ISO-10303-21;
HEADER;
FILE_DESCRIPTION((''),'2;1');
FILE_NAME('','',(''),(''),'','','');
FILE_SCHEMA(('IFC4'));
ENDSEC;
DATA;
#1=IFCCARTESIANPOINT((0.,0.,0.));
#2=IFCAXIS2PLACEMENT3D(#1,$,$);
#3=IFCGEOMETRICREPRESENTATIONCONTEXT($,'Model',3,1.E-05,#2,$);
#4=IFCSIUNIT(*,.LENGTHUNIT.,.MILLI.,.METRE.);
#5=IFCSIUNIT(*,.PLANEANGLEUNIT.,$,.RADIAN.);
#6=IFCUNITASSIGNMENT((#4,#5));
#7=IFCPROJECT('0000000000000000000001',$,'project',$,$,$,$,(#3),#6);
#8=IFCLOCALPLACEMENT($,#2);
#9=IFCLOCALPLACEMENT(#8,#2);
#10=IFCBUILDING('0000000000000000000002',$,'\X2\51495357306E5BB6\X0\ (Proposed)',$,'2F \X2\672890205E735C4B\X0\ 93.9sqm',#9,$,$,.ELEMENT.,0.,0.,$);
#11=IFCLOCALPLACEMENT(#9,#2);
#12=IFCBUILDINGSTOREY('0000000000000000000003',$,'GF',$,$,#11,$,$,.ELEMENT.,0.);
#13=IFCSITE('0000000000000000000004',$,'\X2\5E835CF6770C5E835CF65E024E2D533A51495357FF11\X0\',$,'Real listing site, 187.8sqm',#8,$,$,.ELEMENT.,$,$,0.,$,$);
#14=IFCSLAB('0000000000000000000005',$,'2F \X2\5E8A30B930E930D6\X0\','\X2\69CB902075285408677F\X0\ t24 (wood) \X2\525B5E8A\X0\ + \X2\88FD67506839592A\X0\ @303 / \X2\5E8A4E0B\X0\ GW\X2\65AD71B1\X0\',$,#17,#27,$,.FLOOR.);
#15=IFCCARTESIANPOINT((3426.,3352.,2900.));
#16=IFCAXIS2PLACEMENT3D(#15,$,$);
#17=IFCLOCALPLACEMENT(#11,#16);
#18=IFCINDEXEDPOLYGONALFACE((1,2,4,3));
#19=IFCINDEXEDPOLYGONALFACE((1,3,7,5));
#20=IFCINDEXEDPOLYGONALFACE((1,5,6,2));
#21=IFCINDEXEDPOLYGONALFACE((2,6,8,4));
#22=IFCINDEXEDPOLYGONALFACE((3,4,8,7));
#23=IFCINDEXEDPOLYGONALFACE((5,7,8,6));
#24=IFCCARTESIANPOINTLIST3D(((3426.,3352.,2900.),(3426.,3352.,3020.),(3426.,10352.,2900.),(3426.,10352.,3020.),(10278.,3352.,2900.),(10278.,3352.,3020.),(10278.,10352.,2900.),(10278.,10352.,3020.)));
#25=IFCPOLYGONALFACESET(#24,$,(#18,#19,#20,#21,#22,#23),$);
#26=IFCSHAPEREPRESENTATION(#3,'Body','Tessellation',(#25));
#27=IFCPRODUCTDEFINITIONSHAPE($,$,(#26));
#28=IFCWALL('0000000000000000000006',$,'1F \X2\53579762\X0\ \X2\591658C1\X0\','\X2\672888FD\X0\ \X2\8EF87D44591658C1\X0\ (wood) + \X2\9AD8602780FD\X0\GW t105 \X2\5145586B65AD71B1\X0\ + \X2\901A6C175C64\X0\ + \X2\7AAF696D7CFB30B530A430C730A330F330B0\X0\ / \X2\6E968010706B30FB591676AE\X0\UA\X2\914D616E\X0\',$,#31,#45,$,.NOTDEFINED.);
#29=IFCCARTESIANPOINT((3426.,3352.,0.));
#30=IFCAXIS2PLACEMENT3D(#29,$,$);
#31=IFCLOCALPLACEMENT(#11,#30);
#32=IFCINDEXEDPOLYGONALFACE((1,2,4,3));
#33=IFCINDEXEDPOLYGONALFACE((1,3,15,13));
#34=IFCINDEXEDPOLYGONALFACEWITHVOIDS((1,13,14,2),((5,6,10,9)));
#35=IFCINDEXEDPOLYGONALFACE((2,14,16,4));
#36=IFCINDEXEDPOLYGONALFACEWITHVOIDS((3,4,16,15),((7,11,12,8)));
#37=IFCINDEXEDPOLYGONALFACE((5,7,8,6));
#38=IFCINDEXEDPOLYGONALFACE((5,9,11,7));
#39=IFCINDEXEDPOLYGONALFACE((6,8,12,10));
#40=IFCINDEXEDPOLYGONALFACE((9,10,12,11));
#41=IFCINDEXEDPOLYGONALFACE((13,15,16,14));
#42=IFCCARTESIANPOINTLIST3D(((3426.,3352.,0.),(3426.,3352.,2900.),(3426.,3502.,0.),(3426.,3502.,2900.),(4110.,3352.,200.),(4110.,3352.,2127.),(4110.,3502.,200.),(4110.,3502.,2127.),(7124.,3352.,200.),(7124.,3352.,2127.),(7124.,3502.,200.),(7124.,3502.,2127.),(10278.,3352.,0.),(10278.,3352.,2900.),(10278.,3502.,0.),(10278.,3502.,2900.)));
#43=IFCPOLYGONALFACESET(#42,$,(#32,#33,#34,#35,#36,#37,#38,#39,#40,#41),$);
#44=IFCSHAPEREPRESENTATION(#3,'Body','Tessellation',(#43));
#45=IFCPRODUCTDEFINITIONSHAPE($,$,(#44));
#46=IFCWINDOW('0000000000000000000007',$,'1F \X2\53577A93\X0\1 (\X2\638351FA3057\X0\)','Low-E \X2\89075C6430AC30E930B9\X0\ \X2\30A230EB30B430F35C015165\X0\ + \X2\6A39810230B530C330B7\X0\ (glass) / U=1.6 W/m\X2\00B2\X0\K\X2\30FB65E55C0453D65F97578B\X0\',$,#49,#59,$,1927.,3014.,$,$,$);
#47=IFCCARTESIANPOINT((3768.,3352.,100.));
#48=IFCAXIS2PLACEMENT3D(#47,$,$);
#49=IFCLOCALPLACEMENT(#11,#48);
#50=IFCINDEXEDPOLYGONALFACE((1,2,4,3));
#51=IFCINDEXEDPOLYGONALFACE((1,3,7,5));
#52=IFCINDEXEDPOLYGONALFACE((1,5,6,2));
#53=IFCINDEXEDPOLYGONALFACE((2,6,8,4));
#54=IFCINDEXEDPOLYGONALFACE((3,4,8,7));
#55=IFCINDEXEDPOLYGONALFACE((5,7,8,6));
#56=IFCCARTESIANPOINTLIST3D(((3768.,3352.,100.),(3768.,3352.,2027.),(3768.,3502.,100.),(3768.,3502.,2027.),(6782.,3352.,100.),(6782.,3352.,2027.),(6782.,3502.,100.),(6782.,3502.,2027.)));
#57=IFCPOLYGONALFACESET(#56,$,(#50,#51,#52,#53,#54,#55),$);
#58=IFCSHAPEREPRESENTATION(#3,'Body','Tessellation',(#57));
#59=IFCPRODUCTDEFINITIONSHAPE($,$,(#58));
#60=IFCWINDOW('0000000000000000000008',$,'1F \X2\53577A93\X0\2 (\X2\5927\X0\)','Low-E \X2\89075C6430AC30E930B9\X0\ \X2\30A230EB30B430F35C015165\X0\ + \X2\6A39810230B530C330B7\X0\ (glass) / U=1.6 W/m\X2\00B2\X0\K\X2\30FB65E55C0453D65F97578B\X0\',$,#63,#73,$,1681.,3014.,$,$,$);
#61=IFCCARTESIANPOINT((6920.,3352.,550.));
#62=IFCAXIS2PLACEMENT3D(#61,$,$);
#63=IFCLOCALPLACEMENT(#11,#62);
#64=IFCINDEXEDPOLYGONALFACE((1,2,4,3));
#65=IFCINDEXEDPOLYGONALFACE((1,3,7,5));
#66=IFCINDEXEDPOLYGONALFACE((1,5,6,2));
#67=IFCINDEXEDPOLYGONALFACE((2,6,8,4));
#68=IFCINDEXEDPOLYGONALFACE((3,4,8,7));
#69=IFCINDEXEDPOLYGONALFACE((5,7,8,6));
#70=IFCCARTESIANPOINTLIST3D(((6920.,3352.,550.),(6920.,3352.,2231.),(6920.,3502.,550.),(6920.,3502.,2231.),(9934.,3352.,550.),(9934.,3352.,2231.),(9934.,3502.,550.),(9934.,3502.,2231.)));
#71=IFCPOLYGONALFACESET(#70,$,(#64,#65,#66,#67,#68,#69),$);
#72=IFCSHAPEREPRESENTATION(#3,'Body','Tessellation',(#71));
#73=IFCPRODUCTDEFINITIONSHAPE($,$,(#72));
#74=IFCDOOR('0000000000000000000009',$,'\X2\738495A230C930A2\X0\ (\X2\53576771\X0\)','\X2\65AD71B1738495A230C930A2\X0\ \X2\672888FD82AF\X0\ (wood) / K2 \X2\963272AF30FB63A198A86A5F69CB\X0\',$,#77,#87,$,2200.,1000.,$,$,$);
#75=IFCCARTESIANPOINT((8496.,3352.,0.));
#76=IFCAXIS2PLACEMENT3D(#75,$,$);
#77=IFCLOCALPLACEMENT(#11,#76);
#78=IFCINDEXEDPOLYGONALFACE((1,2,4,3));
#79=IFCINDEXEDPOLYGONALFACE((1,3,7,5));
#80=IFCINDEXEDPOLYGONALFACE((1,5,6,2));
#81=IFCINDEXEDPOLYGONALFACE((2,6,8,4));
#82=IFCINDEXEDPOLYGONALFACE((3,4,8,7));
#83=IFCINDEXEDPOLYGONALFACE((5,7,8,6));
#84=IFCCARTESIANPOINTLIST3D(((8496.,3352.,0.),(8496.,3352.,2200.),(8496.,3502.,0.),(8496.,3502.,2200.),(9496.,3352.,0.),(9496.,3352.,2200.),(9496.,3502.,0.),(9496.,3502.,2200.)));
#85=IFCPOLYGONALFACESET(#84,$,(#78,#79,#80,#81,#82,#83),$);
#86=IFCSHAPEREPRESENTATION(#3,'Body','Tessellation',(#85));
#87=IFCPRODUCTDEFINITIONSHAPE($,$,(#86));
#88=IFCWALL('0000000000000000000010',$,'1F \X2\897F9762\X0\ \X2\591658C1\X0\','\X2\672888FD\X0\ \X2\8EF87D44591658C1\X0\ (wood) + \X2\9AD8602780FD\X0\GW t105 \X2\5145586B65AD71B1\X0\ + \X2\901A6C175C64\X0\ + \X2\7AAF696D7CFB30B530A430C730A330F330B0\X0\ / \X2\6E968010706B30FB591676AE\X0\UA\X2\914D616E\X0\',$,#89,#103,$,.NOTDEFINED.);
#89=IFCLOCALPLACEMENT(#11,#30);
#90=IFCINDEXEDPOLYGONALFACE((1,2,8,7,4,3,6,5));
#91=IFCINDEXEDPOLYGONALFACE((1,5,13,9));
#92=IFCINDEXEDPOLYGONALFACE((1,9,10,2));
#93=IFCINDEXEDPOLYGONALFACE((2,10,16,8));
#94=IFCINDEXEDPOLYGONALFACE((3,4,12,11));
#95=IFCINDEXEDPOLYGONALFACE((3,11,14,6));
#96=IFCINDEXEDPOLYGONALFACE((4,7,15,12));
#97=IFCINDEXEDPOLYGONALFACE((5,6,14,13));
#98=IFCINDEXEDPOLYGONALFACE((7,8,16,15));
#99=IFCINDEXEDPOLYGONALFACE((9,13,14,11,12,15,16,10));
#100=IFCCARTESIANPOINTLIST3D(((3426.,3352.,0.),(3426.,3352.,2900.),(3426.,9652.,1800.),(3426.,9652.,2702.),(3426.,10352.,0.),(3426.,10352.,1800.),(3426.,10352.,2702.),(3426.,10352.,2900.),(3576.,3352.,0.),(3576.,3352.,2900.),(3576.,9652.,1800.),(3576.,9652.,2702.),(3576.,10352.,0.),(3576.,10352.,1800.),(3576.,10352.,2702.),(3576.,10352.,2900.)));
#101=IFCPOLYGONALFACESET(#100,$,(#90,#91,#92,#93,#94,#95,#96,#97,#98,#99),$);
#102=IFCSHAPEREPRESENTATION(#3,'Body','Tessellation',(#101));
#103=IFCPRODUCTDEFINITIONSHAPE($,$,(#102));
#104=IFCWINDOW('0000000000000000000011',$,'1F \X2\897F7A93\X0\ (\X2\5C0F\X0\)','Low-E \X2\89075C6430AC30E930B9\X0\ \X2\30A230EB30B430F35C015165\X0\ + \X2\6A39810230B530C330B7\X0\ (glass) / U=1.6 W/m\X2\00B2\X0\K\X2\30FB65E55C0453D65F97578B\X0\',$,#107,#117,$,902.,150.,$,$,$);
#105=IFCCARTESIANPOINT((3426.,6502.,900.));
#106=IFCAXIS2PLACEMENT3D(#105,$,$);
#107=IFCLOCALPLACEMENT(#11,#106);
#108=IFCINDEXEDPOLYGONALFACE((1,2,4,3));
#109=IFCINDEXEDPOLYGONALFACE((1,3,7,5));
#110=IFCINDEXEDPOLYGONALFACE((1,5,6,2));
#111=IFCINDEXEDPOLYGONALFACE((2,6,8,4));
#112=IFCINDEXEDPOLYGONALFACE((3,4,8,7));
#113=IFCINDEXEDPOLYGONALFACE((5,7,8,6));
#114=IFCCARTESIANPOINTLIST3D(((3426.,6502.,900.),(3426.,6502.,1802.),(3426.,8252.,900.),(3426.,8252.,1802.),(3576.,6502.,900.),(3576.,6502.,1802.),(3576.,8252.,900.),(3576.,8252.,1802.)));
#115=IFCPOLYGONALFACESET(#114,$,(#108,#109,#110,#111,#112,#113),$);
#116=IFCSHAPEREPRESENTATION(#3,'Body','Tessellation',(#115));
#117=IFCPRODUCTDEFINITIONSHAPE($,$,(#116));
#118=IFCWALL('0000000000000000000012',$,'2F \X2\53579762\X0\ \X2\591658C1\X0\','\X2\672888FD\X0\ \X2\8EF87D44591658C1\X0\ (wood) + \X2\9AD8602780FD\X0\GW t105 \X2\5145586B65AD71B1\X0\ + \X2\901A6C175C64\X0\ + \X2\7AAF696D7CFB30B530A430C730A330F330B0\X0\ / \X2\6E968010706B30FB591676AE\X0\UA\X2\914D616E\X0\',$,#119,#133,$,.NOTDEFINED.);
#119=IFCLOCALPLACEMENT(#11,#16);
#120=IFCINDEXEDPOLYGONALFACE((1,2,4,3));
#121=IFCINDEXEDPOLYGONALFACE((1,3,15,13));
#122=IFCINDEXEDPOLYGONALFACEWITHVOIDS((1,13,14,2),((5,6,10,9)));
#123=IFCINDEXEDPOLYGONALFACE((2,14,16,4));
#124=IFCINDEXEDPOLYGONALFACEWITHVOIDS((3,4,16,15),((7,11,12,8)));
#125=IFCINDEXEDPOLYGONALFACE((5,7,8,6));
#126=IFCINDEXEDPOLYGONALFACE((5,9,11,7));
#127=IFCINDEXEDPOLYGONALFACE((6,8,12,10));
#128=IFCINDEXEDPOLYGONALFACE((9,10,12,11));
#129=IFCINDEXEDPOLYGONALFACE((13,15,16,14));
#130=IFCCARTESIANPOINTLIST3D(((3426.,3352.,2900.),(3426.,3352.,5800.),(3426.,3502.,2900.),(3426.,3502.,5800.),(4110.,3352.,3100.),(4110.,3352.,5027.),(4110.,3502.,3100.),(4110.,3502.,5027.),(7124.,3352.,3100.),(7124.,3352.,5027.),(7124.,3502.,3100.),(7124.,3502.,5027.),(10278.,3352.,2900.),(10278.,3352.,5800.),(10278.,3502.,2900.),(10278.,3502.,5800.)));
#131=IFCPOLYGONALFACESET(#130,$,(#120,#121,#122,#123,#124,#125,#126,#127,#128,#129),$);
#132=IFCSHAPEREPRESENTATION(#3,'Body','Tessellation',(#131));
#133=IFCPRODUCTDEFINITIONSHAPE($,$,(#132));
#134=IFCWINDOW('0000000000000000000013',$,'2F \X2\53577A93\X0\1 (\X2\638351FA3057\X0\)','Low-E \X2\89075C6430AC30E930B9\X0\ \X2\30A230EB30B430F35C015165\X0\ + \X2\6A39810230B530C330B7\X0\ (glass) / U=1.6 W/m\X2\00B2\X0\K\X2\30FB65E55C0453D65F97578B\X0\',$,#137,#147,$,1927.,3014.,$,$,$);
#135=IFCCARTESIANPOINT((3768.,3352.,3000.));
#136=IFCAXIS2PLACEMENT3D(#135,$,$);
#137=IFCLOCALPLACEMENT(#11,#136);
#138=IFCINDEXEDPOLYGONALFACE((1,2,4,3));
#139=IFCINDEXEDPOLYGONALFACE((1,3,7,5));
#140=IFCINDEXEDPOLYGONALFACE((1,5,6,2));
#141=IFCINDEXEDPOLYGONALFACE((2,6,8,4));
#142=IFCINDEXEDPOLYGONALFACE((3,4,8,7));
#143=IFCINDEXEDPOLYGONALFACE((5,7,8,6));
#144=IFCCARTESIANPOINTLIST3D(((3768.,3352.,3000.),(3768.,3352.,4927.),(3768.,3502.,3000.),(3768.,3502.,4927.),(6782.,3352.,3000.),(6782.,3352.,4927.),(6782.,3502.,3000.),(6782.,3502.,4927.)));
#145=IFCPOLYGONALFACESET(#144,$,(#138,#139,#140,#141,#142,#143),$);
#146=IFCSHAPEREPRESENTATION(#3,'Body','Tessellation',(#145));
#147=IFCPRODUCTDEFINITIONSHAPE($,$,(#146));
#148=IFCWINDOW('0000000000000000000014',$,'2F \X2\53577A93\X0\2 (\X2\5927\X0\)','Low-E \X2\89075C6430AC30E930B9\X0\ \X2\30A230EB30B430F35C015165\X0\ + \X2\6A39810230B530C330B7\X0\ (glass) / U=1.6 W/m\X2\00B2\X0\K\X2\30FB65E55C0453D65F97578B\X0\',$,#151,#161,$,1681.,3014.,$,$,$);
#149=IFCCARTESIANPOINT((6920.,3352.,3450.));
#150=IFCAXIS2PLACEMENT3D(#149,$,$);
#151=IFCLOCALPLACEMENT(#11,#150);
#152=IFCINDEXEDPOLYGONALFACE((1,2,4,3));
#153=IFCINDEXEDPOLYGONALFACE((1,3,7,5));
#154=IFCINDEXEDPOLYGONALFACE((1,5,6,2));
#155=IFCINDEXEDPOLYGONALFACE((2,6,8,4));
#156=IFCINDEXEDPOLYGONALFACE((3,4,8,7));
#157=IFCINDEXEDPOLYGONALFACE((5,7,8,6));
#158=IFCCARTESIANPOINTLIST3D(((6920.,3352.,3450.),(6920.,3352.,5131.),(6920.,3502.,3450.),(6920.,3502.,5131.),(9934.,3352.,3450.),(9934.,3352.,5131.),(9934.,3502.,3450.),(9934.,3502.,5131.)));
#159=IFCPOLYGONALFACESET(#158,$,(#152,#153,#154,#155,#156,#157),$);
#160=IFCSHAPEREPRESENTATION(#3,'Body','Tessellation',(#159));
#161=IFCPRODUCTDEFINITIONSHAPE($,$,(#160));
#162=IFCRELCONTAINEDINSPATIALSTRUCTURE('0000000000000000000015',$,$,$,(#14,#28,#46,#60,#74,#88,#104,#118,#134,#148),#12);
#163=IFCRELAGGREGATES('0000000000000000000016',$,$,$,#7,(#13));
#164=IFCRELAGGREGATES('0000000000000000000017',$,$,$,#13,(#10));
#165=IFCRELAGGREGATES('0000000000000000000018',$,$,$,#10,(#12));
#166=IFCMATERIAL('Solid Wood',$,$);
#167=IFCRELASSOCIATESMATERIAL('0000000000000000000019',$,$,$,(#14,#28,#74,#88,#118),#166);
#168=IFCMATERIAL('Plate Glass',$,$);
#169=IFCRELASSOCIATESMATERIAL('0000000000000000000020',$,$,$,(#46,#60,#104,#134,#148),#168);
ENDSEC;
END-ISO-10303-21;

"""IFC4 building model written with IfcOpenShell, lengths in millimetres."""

from ifc_helpers import new_model, si_unit, frame, frame_2d, origin, place, context, project, spatial, rectangle, extrude, material, element, fill, save


model = new_model("IFC4")

# Units and contexts
model_context = context("Model", 3, precision=1e-05, world=origin())
ifc_project = project(units=[si_unit("LENGTHUNIT", "METRE", prefix="MILLI"), si_unit("PLANEANGLEUNIT", "RADIAN")], contexts=[model_context])

# Site, building, storey
site_placement = place(None, origin())
site = spatial("IfcSite", under=ifc_project, at=site_placement, Name="広島県広島市中区光南１", ObjectType="Real listing site, 187.8sqm", CompositionType="ELEMENT", RefElevation=0.0)
building_placement = place(site_placement, origin())
building = spatial("IfcBuilding", under=site, at=building_placement, Name="光南の家 (Proposed)", ObjectType="2F 木造平屋 93.9sqm", CompositionType="ELEMENT", ElevationOfRefHeight=0.0, ElevationOfTerrain=0.0)
storey_placement = place(building_placement, origin())
storey = spatial("IfcBuildingStorey", under=building, at=storey_placement, Name="GF", CompositionType="ELEMENT", Elevation=0.0)

# Slab
ifc_material_1 = material(Name="Solid Wood")
slab_1_placement = place(storey_placement, frame((3426.0, 3352.0, 2900.0)))
element("IfcSlab", 1, at=slab_1_placement, inside=storey, material=ifc_material_1, Name="2F 床スラブ", Description="構造用合板 t24 (wood) 剛床 + 製材根太 @303 / 床下 GW断熱", PredefinedType="FLOOR", context=model_context, shape_type="SweptSolid", body=[
    extrude(rectangle(XDim=6852.0, YDim=7000.0, at=frame_2d((3426.0, 3500.0))), frame((3426.0, 3352.0, 2900.0)), (0.0, 0.0, 1.0), 120.0),
])

# Wall, openings, windows, door
wall_1_placement = place(storey_placement, frame((3426.0, 3352.0, 0.0)))
wall_1 = element("IfcWall", 2, at=wall_1_placement, inside=storey, material=ifc_material_1, Name="1F 南面 外壁", Description="木製 軸組外壁 (wood) + 高性能GW t105 充填断熱 + 通気層 + 窯業系サイディング / 準耐火・外皮UA配慮", PredefinedType="NOTDEFINED", context=model_context, shape_type="SweptSolid", body=[
    extrude(rectangle(XDim=6852.0, YDim=150.0, at=frame_2d((3426.0, 75.0))), frame((3426.0, 3352.0, 0.0)), (0.0, 0.0, 1.0), 2900.0),
])
opening_1_placement = place(storey_placement, frame((3768.0, 3352.0, 100.0)))
opening_1 = element("IfcOpeningElement", 3, at=opening_1_placement, cuts=wall_1, PredefinedType="NOTDEFINED", context=model_context, shape_type="SweptSolid", body=[
    extrude(rectangle(XDim=3014.0, YDim=150.0, at=frame_2d((1507.0, 75.0))), frame((3768.0, 3352.0, 100.0)), (0.0, 0.0, 1.0), 1927.0),
])
opening_2_placement = place(storey_placement, frame((6920.0, 3352.0, 550.0)))
opening_2 = element("IfcOpeningElement", 4, at=opening_2_placement, cuts=wall_1, PredefinedType="NOTDEFINED", context=model_context, shape_type="SweptSolid", body=[
    extrude(rectangle(XDim=3014.0, YDim=150.0, at=frame_2d((1507.0, 75.0))), frame((6920.0, 3352.0, 550.0)), (0.0, 0.0, 1.0), 1681.0),
])
opening_3_placement = place(storey_placement, frame((8496.0, 3352.0, 0.0)))
opening_3 = element("IfcOpeningElement", 5, at=opening_3_placement, cuts=wall_1, PredefinedType="NOTDEFINED", context=model_context, shape_type="SweptSolid", body=[
    extrude(rectangle(XDim=1000.0, YDim=150.0, at=frame_2d((500.0, 75.0))), frame((8496.0, 3352.0, 0.0)), (0.0, 0.0, 1.0), 2200.0),
])
ifc_material_2 = material(Name="Plate Glass")
window_1_placement = place(storey_placement, frame((3768.0, 3352.0, 100.0)))
window_1 = element("IfcWindow", 6, at=window_1_placement, inside=storey, material=ifc_material_2, Name="1F 南窓1 (掃出し)", Description="Low-E 複層ガラス アルゴン封入 + 樹脂サッシ (glass) / U=1.6 W/m²K・日射取得型", OverallHeight=1927.0, OverallWidth=3014.0, context=model_context, shape_type="SweptSolid", body=[
    extrude(rectangle(XDim=3014.0, YDim=150.0, at=frame_2d((1507.0, 75.0))), frame((3768.0, 3352.0, 100.0)), (0.0, 0.0, 1.0), 1927.0),
])
fill(opening_1, window_1)
window_2_placement = place(storey_placement, frame((6920.0, 3352.0, 550.0)))
window_2 = element("IfcWindow", 7, at=window_2_placement, inside=storey, material=ifc_material_2, Name="1F 南窓2 (大)", Description="Low-E 複層ガラス アルゴン封入 + 樹脂サッシ (glass) / U=1.6 W/m²K・日射取得型", OverallHeight=1681.0, OverallWidth=3014.0, context=model_context, shape_type="SweptSolid", body=[
    extrude(rectangle(XDim=3014.0, YDim=150.0, at=frame_2d((1507.0, 75.0))), frame((6920.0, 3352.0, 550.0)), (0.0, 0.0, 1.0), 1681.0),
])
fill(opening_2, window_2)
door_placement = place(storey_placement, frame((8496.0, 3352.0, 0.0)))
door = element("IfcDoor", 8, at=door_placement, inside=storey, material=ifc_material_1, Name="玄関ドア (南東)", Description="断熱玄関ドア 木製芯 (wood) / K2 防犯・採風機構", OverallHeight=2200.0, OverallWidth=1000.0, context=model_context, shape_type="SweptSolid", body=[
    extrude(rectangle(XDim=1000.0, YDim=150.0, at=frame_2d((500.0, 75.0))), frame((8496.0, 3352.0, 0.0)), (0.0, 0.0, 1.0), 2200.0),
])
fill(opening_3, door)

# Wall, opening, window
wall_2_placement = place(storey_placement, frame((3426.0, 3352.0, 0.0)))
wall_2 = element("IfcWall", 9, at=wall_2_placement, inside=storey, material=ifc_material_1, Name="1F 西面 外壁", Description="木製 軸組外壁 (wood) + 高性能GW t105 充填断熱 + 通気層 + 窯業系サイディング / 準耐火・外皮UA配慮", PredefinedType="NOTDEFINED", context=model_context, shape_type="SweptSolid", body=[
    extrude(rectangle(XDim=150.0, YDim=7000.0, at=frame_2d((75.0, 3500.0))), frame((3426.0, 3352.0, 0.0)), (0.0, 0.0, 1.0), 2900.0),
])
opening_4_placement = place(storey_placement, frame((3426.0, 6502.0, 900.0)))
opening_4 = element("IfcOpeningElement", 10, at=opening_4_placement, cuts=wall_2, PredefinedType="NOTDEFINED", context=model_context, shape_type="SweptSolid", body=[
    extrude(rectangle(XDim=150.0, YDim=1750.0, at=frame_2d((75.0, 875.0))), frame((3426.0, 6502.0, 900.0)), (0.0, 0.0, 1.0), 902.0),
])
window_3_placement = place(storey_placement, frame((3426.0, 6502.0, 900.0)))
window_3 = element("IfcWindow", 11, at=window_3_placement, inside=storey, material=ifc_material_2, Name="1F 西窓 (小)", Description="Low-E 複層ガラス アルゴン封入 + 樹脂サッシ (glass) / U=1.6 W/m²K・日射取得型", OverallHeight=902.0, OverallWidth=150.0, context=model_context, shape_type="SweptSolid", body=[
    extrude(rectangle(XDim=150.0, YDim=1750.0, at=frame_2d((75.0, 875.0))), frame((3426.0, 6502.0, 900.0)), (0.0, 0.0, 1.0), 902.0),
])
fill(opening_4, window_3)

# Wall, openings, windows
wall_3_placement = place(storey_placement, frame((3426.0, 3352.0, 2900.0)))
wall_3 = element("IfcWall", 12, at=wall_3_placement, inside=storey, material=ifc_material_1, Name="2F 南面 外壁", Description="木製 軸組外壁 (wood) + 高性能GW t105 充填断熱 + 通気層 + 窯業系サイディング / 準耐火・外皮UA配慮", PredefinedType="NOTDEFINED", context=model_context, shape_type="SweptSolid", body=[
    extrude(rectangle(XDim=6852.0, YDim=150.0, at=frame_2d((3426.0, 75.0))), frame((3426.0, 3352.0, 2900.0)), (0.0, 0.0, 1.0), 2900.0),
])
opening_5_placement = place(storey_placement, frame((3768.0, 3352.0, 3000.0)))
opening_5 = element("IfcOpeningElement", 13, at=opening_5_placement, cuts=wall_3, PredefinedType="NOTDEFINED", context=model_context, shape_type="SweptSolid", body=[
    extrude(rectangle(XDim=3014.0, YDim=150.0, at=frame_2d((1507.0, 75.0))), frame((3768.0, 3352.0, 3000.0)), (0.0, 0.0, 1.0), 1927.0),
])
opening_6_placement = place(storey_placement, frame((6920.0, 3352.0, 3450.0)))
opening_6 = element("IfcOpeningElement", 14, at=opening_6_placement, cuts=wall_3, PredefinedType="NOTDEFINED", context=model_context, shape_type="SweptSolid", body=[
    extrude(rectangle(XDim=3014.0, YDim=150.0, at=frame_2d((1507.0, 75.0))), frame((6920.0, 3352.0, 3450.0)), (0.0, 0.0, 1.0), 1681.0),
])
window_4_placement = place(storey_placement, frame((3768.0, 3352.0, 3000.0)))
window_4 = element("IfcWindow", 15, at=window_4_placement, inside=storey, material=ifc_material_2, Name="2F 南窓1 (掃出し)", Description="Low-E 複層ガラス アルゴン封入 + 樹脂サッシ (glass) / U=1.6 W/m²K・日射取得型", OverallHeight=1927.0, OverallWidth=3014.0, context=model_context, shape_type="SweptSolid", body=[
    extrude(rectangle(XDim=3014.0, YDim=150.0, at=frame_2d((1507.0, 75.0))), frame((3768.0, 3352.0, 3000.0)), (0.0, 0.0, 1.0), 1927.0),
])
fill(opening_5, window_4)
window_5_placement = place(storey_placement, frame((6920.0, 3352.0, 3450.0)))
window_5 = element("IfcWindow", 16, at=window_5_placement, inside=storey, material=ifc_material_2, Name="2F 南窓2 (大)", Description="Low-E 複層ガラス アルゴン封入 + 樹脂サッシ (glass) / U=1.6 W/m²K・日射取得型", OverallHeight=1681.0, OverallWidth=3014.0, context=model_context, shape_type="SweptSolid", body=[
    extrude(rectangle(XDim=3014.0, YDim=150.0, at=frame_2d((1507.0, 75.0))), frame((6920.0, 3352.0, 3450.0)), (0.0, 0.0, 1.0), 1681.0),
])
fill(opening_6, window_5)

save(model, "model.ifc")
